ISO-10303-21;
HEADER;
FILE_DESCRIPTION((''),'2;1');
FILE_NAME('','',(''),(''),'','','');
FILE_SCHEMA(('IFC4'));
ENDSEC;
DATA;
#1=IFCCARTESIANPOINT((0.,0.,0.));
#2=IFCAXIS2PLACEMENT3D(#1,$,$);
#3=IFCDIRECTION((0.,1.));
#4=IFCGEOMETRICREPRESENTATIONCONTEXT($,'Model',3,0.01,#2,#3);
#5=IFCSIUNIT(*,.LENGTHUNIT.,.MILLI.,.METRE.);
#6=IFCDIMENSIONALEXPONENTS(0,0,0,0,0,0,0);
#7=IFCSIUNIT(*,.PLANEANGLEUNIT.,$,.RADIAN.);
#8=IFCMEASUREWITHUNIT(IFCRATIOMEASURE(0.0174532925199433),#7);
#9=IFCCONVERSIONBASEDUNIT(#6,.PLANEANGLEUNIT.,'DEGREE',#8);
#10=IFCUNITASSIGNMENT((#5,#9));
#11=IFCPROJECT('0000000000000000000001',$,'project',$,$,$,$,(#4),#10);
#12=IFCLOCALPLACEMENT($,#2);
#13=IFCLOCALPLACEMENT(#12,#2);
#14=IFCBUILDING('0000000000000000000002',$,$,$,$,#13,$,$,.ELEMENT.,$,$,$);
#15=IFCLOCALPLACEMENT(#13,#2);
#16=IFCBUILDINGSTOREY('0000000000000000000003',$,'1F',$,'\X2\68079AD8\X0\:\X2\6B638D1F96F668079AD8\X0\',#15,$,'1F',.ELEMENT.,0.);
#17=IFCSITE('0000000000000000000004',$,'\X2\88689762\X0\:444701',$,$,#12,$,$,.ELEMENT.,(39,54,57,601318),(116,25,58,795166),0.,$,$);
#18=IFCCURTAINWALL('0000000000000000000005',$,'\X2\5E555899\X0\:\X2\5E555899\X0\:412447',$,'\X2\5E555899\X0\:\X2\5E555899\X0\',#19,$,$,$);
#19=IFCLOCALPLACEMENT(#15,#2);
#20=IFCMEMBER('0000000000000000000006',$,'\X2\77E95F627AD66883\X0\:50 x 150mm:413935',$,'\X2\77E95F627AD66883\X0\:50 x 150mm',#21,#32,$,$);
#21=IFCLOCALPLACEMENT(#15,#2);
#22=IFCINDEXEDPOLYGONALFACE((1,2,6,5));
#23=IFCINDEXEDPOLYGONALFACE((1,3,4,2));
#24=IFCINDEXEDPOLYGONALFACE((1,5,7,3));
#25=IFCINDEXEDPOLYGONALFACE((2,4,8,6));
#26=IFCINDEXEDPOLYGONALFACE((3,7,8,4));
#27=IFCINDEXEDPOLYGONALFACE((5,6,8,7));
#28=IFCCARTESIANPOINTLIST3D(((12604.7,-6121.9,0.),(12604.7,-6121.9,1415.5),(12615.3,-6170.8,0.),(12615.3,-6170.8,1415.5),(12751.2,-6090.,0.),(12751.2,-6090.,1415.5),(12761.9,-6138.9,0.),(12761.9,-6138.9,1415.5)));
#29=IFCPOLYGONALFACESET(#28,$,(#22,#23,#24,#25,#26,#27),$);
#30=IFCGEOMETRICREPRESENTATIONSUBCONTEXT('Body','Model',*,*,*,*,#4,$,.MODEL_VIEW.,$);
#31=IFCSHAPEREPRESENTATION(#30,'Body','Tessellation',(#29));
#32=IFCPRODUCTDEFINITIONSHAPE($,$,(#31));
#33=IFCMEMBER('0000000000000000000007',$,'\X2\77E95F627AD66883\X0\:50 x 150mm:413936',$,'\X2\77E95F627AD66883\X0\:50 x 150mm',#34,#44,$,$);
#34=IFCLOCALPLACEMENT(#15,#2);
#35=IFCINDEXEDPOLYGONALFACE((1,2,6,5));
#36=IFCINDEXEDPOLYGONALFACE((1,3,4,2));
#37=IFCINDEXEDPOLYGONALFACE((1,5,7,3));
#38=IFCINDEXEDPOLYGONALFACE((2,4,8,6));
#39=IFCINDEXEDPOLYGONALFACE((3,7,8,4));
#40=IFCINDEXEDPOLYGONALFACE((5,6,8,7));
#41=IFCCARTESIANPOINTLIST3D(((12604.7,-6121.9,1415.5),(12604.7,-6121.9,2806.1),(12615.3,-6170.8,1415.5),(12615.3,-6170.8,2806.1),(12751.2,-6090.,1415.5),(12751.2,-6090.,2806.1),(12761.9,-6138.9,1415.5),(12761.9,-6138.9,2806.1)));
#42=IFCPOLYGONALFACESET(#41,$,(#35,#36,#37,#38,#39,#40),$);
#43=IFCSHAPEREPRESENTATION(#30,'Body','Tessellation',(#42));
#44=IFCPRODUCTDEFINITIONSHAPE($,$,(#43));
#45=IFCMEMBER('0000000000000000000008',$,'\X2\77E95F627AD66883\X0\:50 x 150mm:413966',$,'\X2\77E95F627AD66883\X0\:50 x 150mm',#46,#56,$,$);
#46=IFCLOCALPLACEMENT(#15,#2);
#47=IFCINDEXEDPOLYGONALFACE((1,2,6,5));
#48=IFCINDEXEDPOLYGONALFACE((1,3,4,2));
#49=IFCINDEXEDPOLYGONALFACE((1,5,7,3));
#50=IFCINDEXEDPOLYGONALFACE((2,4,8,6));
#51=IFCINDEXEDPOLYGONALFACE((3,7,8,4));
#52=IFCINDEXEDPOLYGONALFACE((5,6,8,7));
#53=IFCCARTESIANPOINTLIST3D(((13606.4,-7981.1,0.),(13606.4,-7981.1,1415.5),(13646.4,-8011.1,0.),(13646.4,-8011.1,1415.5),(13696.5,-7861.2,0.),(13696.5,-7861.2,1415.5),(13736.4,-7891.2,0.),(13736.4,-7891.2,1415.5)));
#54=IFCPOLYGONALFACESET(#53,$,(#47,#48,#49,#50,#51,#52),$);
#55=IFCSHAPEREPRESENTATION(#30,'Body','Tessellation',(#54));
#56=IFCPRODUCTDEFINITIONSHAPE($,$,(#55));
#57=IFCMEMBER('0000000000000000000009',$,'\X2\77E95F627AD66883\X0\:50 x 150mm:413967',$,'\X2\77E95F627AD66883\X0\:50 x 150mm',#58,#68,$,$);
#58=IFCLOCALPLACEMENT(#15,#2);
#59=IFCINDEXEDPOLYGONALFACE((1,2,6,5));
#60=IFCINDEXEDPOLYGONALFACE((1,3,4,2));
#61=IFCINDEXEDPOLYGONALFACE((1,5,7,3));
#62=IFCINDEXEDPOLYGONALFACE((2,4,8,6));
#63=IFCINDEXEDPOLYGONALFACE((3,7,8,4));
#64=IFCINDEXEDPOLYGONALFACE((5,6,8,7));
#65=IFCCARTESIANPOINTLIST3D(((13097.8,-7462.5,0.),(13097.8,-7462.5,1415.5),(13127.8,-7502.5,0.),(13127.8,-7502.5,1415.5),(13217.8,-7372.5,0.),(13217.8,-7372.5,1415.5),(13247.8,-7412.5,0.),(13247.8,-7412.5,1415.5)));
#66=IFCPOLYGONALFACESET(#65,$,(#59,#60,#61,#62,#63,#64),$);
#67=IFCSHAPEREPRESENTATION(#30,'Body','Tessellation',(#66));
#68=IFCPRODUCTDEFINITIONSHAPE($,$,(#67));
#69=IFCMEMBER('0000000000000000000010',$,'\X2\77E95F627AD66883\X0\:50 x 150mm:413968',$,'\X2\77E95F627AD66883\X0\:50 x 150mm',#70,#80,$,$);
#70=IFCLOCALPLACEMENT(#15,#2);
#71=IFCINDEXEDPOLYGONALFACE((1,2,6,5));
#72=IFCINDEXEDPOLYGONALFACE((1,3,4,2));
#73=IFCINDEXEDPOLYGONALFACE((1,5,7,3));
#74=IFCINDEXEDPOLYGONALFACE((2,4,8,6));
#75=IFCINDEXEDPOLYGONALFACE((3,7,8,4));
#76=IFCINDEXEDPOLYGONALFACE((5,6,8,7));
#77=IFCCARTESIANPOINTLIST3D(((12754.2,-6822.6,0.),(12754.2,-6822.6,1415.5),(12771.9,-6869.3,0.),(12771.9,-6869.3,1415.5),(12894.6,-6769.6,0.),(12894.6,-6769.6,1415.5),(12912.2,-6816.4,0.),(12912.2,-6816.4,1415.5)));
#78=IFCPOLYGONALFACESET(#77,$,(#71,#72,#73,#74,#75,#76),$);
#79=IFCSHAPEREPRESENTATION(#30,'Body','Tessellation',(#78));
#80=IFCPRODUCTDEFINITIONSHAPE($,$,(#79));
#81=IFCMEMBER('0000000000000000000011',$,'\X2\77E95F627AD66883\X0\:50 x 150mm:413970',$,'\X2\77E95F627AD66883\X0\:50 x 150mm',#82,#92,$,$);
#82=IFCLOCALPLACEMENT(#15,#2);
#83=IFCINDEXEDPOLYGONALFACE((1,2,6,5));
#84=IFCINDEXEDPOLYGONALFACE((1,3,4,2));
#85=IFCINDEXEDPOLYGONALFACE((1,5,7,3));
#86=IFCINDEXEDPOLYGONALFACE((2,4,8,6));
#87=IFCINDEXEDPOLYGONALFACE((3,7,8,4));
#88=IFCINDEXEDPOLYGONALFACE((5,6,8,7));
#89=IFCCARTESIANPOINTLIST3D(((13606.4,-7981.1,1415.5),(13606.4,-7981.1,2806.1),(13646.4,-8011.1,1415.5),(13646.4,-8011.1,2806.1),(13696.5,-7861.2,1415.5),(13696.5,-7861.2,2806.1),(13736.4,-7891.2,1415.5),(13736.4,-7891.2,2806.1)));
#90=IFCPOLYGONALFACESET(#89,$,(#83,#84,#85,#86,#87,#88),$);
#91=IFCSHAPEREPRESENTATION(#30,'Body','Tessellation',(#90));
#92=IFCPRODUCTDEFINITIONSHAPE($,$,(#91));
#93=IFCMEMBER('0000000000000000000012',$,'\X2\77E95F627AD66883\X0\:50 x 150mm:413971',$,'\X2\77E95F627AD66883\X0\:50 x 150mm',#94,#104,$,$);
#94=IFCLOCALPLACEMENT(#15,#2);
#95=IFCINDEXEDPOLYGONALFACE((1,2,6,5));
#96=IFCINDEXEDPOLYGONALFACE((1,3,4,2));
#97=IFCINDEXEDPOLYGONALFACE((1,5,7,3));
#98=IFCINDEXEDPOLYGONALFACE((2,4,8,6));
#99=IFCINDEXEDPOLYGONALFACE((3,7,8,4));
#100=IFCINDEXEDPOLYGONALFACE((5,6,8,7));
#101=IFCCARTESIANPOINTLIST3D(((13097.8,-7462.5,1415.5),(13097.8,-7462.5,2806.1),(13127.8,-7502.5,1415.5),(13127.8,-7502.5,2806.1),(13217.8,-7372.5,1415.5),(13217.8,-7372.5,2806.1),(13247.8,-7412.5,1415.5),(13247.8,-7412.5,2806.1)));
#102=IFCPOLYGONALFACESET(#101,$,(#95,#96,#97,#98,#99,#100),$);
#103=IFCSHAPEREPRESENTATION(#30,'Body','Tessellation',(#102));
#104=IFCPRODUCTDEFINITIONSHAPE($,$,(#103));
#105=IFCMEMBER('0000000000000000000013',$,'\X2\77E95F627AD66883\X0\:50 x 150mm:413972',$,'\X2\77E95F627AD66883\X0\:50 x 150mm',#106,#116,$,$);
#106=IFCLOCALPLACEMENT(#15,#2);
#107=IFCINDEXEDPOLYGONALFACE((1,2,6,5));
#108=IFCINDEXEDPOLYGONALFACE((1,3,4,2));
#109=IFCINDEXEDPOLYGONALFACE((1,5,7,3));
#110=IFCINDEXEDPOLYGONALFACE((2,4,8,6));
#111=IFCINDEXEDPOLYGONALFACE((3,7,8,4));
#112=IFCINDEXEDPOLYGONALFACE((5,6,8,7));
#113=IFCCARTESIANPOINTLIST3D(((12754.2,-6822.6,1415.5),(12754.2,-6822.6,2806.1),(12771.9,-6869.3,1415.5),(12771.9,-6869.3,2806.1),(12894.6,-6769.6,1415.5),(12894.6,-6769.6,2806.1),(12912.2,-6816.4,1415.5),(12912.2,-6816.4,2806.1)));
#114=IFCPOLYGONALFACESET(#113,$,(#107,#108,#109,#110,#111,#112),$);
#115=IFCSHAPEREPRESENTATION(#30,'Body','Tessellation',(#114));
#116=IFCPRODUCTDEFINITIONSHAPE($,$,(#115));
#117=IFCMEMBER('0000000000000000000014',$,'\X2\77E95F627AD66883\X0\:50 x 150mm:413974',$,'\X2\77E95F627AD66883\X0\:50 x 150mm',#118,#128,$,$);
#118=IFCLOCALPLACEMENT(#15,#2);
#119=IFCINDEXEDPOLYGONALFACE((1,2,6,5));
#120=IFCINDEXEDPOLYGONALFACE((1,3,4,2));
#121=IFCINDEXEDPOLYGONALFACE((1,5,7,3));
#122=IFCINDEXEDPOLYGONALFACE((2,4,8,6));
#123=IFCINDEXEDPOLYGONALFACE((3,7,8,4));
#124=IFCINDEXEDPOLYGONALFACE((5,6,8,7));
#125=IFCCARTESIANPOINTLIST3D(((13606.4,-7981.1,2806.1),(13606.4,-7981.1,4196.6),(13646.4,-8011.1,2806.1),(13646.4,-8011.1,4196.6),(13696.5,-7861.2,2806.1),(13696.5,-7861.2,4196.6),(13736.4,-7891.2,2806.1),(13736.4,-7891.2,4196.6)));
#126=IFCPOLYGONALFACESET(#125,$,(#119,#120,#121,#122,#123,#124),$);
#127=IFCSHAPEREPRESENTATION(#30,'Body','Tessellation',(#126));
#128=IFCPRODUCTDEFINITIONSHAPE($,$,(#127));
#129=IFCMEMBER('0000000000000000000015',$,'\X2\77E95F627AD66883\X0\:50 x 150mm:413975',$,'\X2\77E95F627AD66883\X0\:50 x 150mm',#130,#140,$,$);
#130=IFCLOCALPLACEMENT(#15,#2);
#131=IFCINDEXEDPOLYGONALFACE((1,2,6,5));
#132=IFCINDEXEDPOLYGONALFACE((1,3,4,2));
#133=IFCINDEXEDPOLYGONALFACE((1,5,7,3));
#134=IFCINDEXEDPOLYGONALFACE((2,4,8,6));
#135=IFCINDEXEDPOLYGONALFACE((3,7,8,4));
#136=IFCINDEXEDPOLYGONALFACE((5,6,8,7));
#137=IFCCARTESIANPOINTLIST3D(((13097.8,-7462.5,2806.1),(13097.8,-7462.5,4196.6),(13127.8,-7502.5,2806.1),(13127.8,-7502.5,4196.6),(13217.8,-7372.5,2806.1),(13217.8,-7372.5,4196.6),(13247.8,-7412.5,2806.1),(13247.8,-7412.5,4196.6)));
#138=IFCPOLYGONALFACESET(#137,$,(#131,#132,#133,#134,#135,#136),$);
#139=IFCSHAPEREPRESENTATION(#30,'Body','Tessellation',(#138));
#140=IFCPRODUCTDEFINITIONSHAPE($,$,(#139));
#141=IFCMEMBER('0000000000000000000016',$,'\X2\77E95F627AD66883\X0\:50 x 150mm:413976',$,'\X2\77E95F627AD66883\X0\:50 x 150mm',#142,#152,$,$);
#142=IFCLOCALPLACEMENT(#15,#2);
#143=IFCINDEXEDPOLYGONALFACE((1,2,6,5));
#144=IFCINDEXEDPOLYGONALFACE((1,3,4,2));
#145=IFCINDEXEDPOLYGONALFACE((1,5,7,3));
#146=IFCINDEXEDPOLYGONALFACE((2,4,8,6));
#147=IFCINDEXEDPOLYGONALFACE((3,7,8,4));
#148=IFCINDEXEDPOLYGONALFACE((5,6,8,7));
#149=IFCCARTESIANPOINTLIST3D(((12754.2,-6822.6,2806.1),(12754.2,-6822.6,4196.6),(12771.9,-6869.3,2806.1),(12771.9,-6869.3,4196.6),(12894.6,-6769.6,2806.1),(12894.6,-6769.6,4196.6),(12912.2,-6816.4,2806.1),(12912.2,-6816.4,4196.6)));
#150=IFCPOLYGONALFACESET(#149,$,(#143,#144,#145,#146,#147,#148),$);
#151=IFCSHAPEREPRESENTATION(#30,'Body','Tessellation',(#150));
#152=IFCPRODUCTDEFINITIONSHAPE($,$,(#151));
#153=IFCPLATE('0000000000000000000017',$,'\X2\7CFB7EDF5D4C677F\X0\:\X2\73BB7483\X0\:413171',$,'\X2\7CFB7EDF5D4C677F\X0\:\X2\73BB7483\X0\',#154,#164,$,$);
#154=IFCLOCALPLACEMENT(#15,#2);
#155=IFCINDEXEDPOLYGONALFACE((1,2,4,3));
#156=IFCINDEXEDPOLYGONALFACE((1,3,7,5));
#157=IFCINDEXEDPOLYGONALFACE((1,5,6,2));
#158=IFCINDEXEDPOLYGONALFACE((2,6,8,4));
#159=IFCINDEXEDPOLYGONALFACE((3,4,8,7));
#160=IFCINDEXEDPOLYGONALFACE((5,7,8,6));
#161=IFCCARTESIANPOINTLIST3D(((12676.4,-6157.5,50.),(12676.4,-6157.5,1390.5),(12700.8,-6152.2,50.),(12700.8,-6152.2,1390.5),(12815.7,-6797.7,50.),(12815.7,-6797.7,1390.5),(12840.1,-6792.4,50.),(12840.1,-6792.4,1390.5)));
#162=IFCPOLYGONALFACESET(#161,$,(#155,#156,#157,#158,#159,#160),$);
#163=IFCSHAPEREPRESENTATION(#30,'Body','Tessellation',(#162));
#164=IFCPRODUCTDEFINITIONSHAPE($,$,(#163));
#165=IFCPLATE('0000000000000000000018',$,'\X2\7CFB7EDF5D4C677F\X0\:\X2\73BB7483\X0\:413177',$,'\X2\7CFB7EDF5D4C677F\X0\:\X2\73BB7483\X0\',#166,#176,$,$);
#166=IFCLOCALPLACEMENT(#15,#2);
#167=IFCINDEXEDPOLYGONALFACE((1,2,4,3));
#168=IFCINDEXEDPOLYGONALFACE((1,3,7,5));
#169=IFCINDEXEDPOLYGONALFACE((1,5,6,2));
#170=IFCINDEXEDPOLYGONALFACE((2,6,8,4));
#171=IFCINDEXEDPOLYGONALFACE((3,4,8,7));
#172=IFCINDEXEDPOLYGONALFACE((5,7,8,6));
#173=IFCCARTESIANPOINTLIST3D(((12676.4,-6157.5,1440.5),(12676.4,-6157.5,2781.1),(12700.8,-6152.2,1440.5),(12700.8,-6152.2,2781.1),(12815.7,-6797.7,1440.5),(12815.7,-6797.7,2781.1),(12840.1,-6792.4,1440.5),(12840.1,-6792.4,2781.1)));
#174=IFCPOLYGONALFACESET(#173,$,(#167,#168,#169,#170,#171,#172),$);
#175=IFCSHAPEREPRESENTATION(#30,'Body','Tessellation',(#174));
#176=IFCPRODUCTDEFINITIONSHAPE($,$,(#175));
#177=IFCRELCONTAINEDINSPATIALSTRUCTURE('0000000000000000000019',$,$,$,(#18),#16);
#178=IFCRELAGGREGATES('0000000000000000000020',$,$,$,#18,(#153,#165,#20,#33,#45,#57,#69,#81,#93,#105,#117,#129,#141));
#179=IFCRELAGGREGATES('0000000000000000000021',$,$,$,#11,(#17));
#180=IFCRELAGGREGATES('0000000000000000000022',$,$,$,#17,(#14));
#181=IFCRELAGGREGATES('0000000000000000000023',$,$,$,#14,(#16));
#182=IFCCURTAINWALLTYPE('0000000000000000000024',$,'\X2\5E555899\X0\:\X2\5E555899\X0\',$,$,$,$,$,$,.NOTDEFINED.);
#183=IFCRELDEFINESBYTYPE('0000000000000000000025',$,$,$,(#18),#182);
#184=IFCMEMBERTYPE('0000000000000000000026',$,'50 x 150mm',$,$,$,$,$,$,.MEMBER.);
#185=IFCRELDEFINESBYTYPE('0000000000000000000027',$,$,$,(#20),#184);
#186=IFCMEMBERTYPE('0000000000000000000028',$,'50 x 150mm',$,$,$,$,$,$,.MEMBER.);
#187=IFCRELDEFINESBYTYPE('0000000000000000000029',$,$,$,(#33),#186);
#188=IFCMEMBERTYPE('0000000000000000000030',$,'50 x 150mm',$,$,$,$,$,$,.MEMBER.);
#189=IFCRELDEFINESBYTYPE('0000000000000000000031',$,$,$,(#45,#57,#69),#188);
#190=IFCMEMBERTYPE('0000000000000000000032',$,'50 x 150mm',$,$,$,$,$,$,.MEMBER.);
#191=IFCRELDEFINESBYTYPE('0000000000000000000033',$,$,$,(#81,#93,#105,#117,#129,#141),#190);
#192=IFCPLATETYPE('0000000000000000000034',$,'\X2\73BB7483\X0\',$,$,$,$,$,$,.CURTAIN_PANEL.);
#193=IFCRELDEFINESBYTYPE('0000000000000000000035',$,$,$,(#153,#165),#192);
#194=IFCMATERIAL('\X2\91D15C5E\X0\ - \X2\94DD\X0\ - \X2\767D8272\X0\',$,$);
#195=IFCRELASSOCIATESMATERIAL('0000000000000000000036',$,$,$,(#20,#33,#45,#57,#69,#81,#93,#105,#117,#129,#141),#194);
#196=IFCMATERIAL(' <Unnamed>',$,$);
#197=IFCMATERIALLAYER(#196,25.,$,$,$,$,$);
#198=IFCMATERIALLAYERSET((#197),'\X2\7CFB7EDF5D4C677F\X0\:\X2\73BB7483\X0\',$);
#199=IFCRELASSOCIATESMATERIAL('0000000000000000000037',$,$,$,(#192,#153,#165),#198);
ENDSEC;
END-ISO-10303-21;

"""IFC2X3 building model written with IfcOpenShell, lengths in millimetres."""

from ifc_helpers import new_model, entity, si_unit, converted_unit, direction, frame, frame_2d, origin, origin_2d_with_axis, place, context, subcontext, project, spatial, rectangle, extrude, source, transform, mapped, material, layer, layer_set, layer_usage, type_object, type_shapes, element, aggregate, save


model = new_model("IFC2X3")

# Units and contexts
model_context = context("Model", 3, precision=0.01, world=origin(), true_north=direction((0.0, 1.0)))
body_context = subcontext(model_context, "Body", "Model", "MODEL_VIEW")
ifc_project = project(units=[si_unit("LENGTHUNIT", "METRE", prefix="MILLI"), converted_unit("PLANEANGLEUNIT", "DEGREE", entity("IfcRatioMeasure", 0.0174532925199433), si_unit("PLANEANGLEUNIT", "RADIAN"), dimensions=[0, 0, 0, 0, 0, 0, 0])], contexts=[model_context])

# Site, building, storey
site_placement = place(None, origin())
site = spatial("IfcSite", under=ifc_project, at=site_placement, Name="表面:444701", CompositionType="ELEMENT", RefLatitude=(39, 54, 57, 601318), RefLongitude=(116, 25, 58, 795166), RefElevation=0.0)
building_placement = place(site_placement, origin())
building = spatial("IfcBuilding", under=site, at=building_placement, CompositionType="ELEMENT")
storey_placement = place(building_placement, origin())
storey = spatial("IfcBuildingStorey", under=building, at=storey_placement, Name="1F", ObjectType="标高:正负零标高", LongName="1F", CompositionType="ELEMENT", Elevation=0.0)

# Curtain wall, members, plates
curtain_wall_type = type_object("IfcCurtainWallType", Name="幕墙:幕墙", PredefinedType="NOTDEFINED")
curtain_wall_placement = place(storey_placement, origin())
curtain_wall = element("IfcCurtainWall", 1, at=curtain_wall_placement, inside=storey, type_object=curtain_wall_type, Name="幕墙:幕墙:412447", ObjectType="幕墙:幕墙")
ifc_material_1 = material(Name="金属 - 铝 - 白色")
member_type_1 = type_object("IfcMemberType", Name="50 x 150mm", PredefinedType="MEMBER")
shared_shape_1 = source(origin(), body_context, "Body", "SweptSolid", [
    extrude(rectangle(XDim=150.0, YDim=50.0, at=origin_2d_with_axis()), frame((-25.0, 0.0, -1415.5), z_axis=(0.0, 0.0, 1.0), x_axis=(0.0, -1.0, 0.0)), (0.0, 0.0, 1.0), 1415.5),
])
type_shapes(member_type_1, [shared_shape_1])
member_1_placement = place(storey_placement, frame((12677.9, -6106.0, 0.0), z_axis=(0.0, 0.0, -1.0), x_axis=(-0.21268, 0.977122, 0.0)))
member_1 = element("IfcMember", 2, at=member_1_placement, type_object=member_type_1, material=ifc_material_1, Name="矩形竖梃:50 x 150mm:413935", ObjectType="矩形竖梃:50 x 150mm", context=body_context, shape_type="MappedRepresentation", body=[
    mapped(shared_shape_1, transform((0.0, 0.0, 0.0), scale=1.0)),
])
member_type_2 = type_object("IfcMemberType", Name="50 x 150mm", PredefinedType="MEMBER")
shared_shape_2 = source(origin(), body_context, "Body", "SweptSolid", [
    extrude(rectangle(XDim=150.0, YDim=50.0, at=origin_2d_with_axis()), frame((-25.0, 0.0, -1390.5), z_axis=(0.0, 0.0, 1.0), x_axis=(0.0, -1.0, 0.0)), (0.0, 0.0, 1.0), 1390.5),
])
type_shapes(member_type_2, [shared_shape_2])
member_2_placement = place(storey_placement, frame((12677.9, -6106.0, 1415.5), z_axis=(0.0, 0.0, -1.0), x_axis=(-0.21268, 0.977122, 0.0)))
member_2 = element("IfcMember", 3, at=member_2_placement, type_object=member_type_2, material=ifc_material_1, Name="矩形竖梃:50 x 150mm:413936", ObjectType="矩形竖梃:50 x 150mm", context=body_context, shape_type="MappedRepresentation", body=[
    mapped(shared_shape_2, transform((0.0, 0.0, 0.0), scale=1.0)),
])
member_type_3 = type_object("IfcMemberType", Name="50 x 150mm", PredefinedType="MEMBER")
shared_shape_3 = source(origin(), body_context, "Body", "SweptSolid", [
    extrude(rectangle(XDim=150.0, YDim=50.0, at=origin_2d_with_axis()), frame((0.0, 0.0, -1415.5), z_axis=(0.0, 0.0, 1.0), x_axis=(0.0, -1.0, 0.0)), (0.0, 0.0, 1.0), 1415.5),
])
type_shapes(member_type_3, [shared_shape_3])
member_3_placement = place(storey_placement, frame((13671.4, -7936.1, 0.0), z_axis=(0.0, 0.0, -1.0), x_axis=(-0.799766, 0.600312, 0.0)))
member_3 = element("IfcMember", 4, at=member_3_placement, type_object=member_type_3, material=ifc_material_1, Name="矩形竖梃:50 x 150mm:413966", ObjectType="矩形竖梃:50 x 150mm", context=body_context, shape_type="MappedRepresentation", body=[
    mapped(shared_shape_3, transform((0.0, 0.0, 0.0), scale=1.0)),
])
member_4_placement = place(storey_placement, frame((13172.8, -7437.5, 0.0), z_axis=(0.0, 0.0, -1.0), x_axis=(-0.600312, 0.799766, 0.0)))
member_4 = element("IfcMember", 5, at=member_4_placement, type_object=member_type_3, material=ifc_material_1, Name="矩形竖梃:50 x 150mm:413967", ObjectType="矩形竖梃:50 x 150mm", context=body_context, shape_type="MappedRepresentation", body=[
    mapped(shared_shape_3, transform((0.0, 0.0, 0.0), scale=1.0)),
])
member_5_placement = place(storey_placement, frame((12833.2, -6819.5, 0.0), z_axis=(0.0, 0.0, -1.0), x_axis=(-0.353094, 0.935588, 0.0)))
member_5 = element("IfcMember", 6, at=member_5_placement, type_object=member_type_3, material=ifc_material_1, Name="矩形竖梃:50 x 150mm:413968", ObjectType="矩形竖梃:50 x 150mm", context=body_context, shape_type="MappedRepresentation", body=[
    mapped(shared_shape_3, transform((0.0, 0.0, 0.0), scale=1.0)),
])
member_type_4 = type_object("IfcMemberType", Name="50 x 150mm", PredefinedType="MEMBER")
shared_shape_4 = source(origin(), body_context, "Body", "SweptSolid", [
    extrude(rectangle(XDim=150.0, YDim=50.0, at=origin_2d_with_axis()), frame((0.0, 0.0, -1390.5), z_axis=(0.0, 0.0, 1.0), x_axis=(0.0, -1.0, 0.0)), (0.0, 0.0, 1.0), 1390.5),
])
type_shapes(member_type_4, [shared_shape_4])
member_6_placement = place(storey_placement, frame((13671.4, -7936.1, 1415.5), z_axis=(0.0, 0.0, -1.0), x_axis=(-0.799766, 0.600312, 0.0)))
member_6 = element("IfcMember", 7, at=member_6_placement, type_object=member_type_4, material=ifc_material_1, Name="矩形竖梃:50 x 150mm:413970", ObjectType="矩形竖梃:50 x 150mm", context=body_context, shape_type="MappedRepresentation", body=[
    mapped(shared_shape_4, transform((0.0, 0.0, 0.0), scale=1.0)),
])
member_7_placement = place(storey_placement, frame((13172.8, -7437.5, 1415.5), z_axis=(0.0, 0.0, -1.0), x_axis=(-0.600312, 0.799766, 0.0)))
member_7 = element("IfcMember", 8, at=member_7_placement, type_object=member_type_4, material=ifc_material_1, Name="矩形竖梃:50 x 150mm:413971", ObjectType="矩形竖梃:50 x 150mm", context=body_context, shape_type="MappedRepresentation", body=[
    mapped(shared_shape_4, transform((0.0, 0.0, 0.0), scale=1.0)),
])
member_8_placement = place(storey_placement, frame((12833.2, -6819.5, 1415.5), z_axis=(0.0, 0.0, -1.0), x_axis=(-0.353094, 0.935588, 0.0)))
member_8 = element("IfcMember", 9, at=member_8_placement, type_object=member_type_4, material=ifc_material_1, Name="矩形竖梃:50 x 150mm:413972", ObjectType="矩形竖梃:50 x 150mm", context=body_context, shape_type="MappedRepresentation", body=[
    mapped(shared_shape_4, transform((0.0, 0.0, 0.0), scale=1.0)),
])
member_9_placement = place(storey_placement, frame((13671.4, -7936.1, 2806.1), z_axis=(0.0, 0.0, -1.0), x_axis=(-0.799766, 0.600312, 0.0)))
member_9 = element("IfcMember", 10, at=member_9_placement, type_object=member_type_4, material=ifc_material_1, Name="矩形竖梃:50 x 150mm:413974", ObjectType="矩形竖梃:50 x 150mm", context=body_context, shape_type="MappedRepresentation", body=[
    mapped(shared_shape_4, transform((0.0, 0.0, 0.0), scale=1.0)),
])
member_10_placement = place(storey_placement, frame((13172.8, -7437.5, 2806.1), z_axis=(0.0, 0.0, -1.0), x_axis=(-0.600312, 0.799766, 0.0)))
member_10 = element("IfcMember", 11, at=member_10_placement, type_object=member_type_4, material=ifc_material_1, Name="矩形竖梃:50 x 150mm:413975", ObjectType="矩形竖梃:50 x 150mm", context=body_context, shape_type="MappedRepresentation", body=[
    mapped(shared_shape_4, transform((0.0, 0.0, 0.0), scale=1.0)),
])
member_11_placement = place(storey_placement, frame((12833.2, -6819.5, 2806.1), z_axis=(0.0, 0.0, -1.0), x_axis=(-0.353094, 0.935588, 0.0)))
member_11 = element("IfcMember", 12, at=member_11_placement, type_object=member_type_4, material=ifc_material_1, Name="矩形竖梃:50 x 150mm:413976", ObjectType="矩形竖梃:50 x 150mm", context=body_context, shape_type="MappedRepresentation", body=[
    mapped(shared_shape_4, transform((0.0, 0.0, 0.0), scale=1.0)),
])
ifc_material_2 = material(Name=" <Unnamed>")
ifc_layer_1 = layer(ifc_material_2, 25.0)
ifc_layer_set_1 = layer_set([ifc_layer_1], Name="系统嵌板:玻璃")
ifc_layer_usage_1 = layer_usage(ifc_layer_set_1, "AXIS3", "POSITIVE", 0.0)
plate_type_1 = type_object("IfcPlateType", Name="玻璃", PredefinedType="CURTAIN_PANEL", material=ifc_layer_set_1)
shared_shape_5 = source(origin(), body_context, "Body", "SweptSolid", [
    extrude(rectangle(XDim=25.0, YDim=655.2, at=frame_2d((0.0, 0.0), x_axis=(1.0, 0.0))), frame((0.0, 0.0, 0.0), z_axis=(0.0, 0.0, 1.0), x_axis=(0.0, 1.0, 0.0)), (0.0, 0.0, 1.0), 1340.5),
])
type_shapes(plate_type_1, [shared_shape_5])
plate_1_placement = place(curtain_wall_placement, frame((12758.2, -6474.9, 50.0), z_axis=(0.0, 0.0, 1.0), x_axis=(-0.21268, 0.977122, 0.0)))
plate_1 = element("IfcPlate", 13, at=plate_1_placement, type_object=plate_type_1, material=ifc_layer_usage_1, Name="系统嵌板:玻璃:413171", ObjectType="系统嵌板:玻璃", context=body_context, shape_type="MappedRepresentation", body=[
    mapped(shared_shape_5, transform((0.0, 0.0, 0.0), scale=1.0)),
])
ifc_layer_usage_2 = layer_usage(ifc_layer_set_1, "AXIS3", "POSITIVE", 0.0)
plate_2_placement = place(curtain_wall_placement, frame((12758.2, -6474.9, 1440.5), z_axis=(0.0, 0.0, 1.0), x_axis=(-0.21268, 0.977122, 0.0)))
plate_2 = element("IfcPlate", 14, at=plate_2_placement, type_object=plate_type_1, material=ifc_layer_usage_2, Name="系统嵌板:玻璃:413177", ObjectType="系统嵌板:玻璃", context=body_context, shape_type="MappedRepresentation", body=[
    mapped(shared_shape_5, transform((0.0, 0.0, 0.0), scale=1.0)),
])
aggregate(curtain_wall, [plate_1, plate_2, member_1, member_2, member_3, member_4, member_5, member_6, member_7, member_8, member_9, member_10, member_11])

save(model, "model.ifc")
